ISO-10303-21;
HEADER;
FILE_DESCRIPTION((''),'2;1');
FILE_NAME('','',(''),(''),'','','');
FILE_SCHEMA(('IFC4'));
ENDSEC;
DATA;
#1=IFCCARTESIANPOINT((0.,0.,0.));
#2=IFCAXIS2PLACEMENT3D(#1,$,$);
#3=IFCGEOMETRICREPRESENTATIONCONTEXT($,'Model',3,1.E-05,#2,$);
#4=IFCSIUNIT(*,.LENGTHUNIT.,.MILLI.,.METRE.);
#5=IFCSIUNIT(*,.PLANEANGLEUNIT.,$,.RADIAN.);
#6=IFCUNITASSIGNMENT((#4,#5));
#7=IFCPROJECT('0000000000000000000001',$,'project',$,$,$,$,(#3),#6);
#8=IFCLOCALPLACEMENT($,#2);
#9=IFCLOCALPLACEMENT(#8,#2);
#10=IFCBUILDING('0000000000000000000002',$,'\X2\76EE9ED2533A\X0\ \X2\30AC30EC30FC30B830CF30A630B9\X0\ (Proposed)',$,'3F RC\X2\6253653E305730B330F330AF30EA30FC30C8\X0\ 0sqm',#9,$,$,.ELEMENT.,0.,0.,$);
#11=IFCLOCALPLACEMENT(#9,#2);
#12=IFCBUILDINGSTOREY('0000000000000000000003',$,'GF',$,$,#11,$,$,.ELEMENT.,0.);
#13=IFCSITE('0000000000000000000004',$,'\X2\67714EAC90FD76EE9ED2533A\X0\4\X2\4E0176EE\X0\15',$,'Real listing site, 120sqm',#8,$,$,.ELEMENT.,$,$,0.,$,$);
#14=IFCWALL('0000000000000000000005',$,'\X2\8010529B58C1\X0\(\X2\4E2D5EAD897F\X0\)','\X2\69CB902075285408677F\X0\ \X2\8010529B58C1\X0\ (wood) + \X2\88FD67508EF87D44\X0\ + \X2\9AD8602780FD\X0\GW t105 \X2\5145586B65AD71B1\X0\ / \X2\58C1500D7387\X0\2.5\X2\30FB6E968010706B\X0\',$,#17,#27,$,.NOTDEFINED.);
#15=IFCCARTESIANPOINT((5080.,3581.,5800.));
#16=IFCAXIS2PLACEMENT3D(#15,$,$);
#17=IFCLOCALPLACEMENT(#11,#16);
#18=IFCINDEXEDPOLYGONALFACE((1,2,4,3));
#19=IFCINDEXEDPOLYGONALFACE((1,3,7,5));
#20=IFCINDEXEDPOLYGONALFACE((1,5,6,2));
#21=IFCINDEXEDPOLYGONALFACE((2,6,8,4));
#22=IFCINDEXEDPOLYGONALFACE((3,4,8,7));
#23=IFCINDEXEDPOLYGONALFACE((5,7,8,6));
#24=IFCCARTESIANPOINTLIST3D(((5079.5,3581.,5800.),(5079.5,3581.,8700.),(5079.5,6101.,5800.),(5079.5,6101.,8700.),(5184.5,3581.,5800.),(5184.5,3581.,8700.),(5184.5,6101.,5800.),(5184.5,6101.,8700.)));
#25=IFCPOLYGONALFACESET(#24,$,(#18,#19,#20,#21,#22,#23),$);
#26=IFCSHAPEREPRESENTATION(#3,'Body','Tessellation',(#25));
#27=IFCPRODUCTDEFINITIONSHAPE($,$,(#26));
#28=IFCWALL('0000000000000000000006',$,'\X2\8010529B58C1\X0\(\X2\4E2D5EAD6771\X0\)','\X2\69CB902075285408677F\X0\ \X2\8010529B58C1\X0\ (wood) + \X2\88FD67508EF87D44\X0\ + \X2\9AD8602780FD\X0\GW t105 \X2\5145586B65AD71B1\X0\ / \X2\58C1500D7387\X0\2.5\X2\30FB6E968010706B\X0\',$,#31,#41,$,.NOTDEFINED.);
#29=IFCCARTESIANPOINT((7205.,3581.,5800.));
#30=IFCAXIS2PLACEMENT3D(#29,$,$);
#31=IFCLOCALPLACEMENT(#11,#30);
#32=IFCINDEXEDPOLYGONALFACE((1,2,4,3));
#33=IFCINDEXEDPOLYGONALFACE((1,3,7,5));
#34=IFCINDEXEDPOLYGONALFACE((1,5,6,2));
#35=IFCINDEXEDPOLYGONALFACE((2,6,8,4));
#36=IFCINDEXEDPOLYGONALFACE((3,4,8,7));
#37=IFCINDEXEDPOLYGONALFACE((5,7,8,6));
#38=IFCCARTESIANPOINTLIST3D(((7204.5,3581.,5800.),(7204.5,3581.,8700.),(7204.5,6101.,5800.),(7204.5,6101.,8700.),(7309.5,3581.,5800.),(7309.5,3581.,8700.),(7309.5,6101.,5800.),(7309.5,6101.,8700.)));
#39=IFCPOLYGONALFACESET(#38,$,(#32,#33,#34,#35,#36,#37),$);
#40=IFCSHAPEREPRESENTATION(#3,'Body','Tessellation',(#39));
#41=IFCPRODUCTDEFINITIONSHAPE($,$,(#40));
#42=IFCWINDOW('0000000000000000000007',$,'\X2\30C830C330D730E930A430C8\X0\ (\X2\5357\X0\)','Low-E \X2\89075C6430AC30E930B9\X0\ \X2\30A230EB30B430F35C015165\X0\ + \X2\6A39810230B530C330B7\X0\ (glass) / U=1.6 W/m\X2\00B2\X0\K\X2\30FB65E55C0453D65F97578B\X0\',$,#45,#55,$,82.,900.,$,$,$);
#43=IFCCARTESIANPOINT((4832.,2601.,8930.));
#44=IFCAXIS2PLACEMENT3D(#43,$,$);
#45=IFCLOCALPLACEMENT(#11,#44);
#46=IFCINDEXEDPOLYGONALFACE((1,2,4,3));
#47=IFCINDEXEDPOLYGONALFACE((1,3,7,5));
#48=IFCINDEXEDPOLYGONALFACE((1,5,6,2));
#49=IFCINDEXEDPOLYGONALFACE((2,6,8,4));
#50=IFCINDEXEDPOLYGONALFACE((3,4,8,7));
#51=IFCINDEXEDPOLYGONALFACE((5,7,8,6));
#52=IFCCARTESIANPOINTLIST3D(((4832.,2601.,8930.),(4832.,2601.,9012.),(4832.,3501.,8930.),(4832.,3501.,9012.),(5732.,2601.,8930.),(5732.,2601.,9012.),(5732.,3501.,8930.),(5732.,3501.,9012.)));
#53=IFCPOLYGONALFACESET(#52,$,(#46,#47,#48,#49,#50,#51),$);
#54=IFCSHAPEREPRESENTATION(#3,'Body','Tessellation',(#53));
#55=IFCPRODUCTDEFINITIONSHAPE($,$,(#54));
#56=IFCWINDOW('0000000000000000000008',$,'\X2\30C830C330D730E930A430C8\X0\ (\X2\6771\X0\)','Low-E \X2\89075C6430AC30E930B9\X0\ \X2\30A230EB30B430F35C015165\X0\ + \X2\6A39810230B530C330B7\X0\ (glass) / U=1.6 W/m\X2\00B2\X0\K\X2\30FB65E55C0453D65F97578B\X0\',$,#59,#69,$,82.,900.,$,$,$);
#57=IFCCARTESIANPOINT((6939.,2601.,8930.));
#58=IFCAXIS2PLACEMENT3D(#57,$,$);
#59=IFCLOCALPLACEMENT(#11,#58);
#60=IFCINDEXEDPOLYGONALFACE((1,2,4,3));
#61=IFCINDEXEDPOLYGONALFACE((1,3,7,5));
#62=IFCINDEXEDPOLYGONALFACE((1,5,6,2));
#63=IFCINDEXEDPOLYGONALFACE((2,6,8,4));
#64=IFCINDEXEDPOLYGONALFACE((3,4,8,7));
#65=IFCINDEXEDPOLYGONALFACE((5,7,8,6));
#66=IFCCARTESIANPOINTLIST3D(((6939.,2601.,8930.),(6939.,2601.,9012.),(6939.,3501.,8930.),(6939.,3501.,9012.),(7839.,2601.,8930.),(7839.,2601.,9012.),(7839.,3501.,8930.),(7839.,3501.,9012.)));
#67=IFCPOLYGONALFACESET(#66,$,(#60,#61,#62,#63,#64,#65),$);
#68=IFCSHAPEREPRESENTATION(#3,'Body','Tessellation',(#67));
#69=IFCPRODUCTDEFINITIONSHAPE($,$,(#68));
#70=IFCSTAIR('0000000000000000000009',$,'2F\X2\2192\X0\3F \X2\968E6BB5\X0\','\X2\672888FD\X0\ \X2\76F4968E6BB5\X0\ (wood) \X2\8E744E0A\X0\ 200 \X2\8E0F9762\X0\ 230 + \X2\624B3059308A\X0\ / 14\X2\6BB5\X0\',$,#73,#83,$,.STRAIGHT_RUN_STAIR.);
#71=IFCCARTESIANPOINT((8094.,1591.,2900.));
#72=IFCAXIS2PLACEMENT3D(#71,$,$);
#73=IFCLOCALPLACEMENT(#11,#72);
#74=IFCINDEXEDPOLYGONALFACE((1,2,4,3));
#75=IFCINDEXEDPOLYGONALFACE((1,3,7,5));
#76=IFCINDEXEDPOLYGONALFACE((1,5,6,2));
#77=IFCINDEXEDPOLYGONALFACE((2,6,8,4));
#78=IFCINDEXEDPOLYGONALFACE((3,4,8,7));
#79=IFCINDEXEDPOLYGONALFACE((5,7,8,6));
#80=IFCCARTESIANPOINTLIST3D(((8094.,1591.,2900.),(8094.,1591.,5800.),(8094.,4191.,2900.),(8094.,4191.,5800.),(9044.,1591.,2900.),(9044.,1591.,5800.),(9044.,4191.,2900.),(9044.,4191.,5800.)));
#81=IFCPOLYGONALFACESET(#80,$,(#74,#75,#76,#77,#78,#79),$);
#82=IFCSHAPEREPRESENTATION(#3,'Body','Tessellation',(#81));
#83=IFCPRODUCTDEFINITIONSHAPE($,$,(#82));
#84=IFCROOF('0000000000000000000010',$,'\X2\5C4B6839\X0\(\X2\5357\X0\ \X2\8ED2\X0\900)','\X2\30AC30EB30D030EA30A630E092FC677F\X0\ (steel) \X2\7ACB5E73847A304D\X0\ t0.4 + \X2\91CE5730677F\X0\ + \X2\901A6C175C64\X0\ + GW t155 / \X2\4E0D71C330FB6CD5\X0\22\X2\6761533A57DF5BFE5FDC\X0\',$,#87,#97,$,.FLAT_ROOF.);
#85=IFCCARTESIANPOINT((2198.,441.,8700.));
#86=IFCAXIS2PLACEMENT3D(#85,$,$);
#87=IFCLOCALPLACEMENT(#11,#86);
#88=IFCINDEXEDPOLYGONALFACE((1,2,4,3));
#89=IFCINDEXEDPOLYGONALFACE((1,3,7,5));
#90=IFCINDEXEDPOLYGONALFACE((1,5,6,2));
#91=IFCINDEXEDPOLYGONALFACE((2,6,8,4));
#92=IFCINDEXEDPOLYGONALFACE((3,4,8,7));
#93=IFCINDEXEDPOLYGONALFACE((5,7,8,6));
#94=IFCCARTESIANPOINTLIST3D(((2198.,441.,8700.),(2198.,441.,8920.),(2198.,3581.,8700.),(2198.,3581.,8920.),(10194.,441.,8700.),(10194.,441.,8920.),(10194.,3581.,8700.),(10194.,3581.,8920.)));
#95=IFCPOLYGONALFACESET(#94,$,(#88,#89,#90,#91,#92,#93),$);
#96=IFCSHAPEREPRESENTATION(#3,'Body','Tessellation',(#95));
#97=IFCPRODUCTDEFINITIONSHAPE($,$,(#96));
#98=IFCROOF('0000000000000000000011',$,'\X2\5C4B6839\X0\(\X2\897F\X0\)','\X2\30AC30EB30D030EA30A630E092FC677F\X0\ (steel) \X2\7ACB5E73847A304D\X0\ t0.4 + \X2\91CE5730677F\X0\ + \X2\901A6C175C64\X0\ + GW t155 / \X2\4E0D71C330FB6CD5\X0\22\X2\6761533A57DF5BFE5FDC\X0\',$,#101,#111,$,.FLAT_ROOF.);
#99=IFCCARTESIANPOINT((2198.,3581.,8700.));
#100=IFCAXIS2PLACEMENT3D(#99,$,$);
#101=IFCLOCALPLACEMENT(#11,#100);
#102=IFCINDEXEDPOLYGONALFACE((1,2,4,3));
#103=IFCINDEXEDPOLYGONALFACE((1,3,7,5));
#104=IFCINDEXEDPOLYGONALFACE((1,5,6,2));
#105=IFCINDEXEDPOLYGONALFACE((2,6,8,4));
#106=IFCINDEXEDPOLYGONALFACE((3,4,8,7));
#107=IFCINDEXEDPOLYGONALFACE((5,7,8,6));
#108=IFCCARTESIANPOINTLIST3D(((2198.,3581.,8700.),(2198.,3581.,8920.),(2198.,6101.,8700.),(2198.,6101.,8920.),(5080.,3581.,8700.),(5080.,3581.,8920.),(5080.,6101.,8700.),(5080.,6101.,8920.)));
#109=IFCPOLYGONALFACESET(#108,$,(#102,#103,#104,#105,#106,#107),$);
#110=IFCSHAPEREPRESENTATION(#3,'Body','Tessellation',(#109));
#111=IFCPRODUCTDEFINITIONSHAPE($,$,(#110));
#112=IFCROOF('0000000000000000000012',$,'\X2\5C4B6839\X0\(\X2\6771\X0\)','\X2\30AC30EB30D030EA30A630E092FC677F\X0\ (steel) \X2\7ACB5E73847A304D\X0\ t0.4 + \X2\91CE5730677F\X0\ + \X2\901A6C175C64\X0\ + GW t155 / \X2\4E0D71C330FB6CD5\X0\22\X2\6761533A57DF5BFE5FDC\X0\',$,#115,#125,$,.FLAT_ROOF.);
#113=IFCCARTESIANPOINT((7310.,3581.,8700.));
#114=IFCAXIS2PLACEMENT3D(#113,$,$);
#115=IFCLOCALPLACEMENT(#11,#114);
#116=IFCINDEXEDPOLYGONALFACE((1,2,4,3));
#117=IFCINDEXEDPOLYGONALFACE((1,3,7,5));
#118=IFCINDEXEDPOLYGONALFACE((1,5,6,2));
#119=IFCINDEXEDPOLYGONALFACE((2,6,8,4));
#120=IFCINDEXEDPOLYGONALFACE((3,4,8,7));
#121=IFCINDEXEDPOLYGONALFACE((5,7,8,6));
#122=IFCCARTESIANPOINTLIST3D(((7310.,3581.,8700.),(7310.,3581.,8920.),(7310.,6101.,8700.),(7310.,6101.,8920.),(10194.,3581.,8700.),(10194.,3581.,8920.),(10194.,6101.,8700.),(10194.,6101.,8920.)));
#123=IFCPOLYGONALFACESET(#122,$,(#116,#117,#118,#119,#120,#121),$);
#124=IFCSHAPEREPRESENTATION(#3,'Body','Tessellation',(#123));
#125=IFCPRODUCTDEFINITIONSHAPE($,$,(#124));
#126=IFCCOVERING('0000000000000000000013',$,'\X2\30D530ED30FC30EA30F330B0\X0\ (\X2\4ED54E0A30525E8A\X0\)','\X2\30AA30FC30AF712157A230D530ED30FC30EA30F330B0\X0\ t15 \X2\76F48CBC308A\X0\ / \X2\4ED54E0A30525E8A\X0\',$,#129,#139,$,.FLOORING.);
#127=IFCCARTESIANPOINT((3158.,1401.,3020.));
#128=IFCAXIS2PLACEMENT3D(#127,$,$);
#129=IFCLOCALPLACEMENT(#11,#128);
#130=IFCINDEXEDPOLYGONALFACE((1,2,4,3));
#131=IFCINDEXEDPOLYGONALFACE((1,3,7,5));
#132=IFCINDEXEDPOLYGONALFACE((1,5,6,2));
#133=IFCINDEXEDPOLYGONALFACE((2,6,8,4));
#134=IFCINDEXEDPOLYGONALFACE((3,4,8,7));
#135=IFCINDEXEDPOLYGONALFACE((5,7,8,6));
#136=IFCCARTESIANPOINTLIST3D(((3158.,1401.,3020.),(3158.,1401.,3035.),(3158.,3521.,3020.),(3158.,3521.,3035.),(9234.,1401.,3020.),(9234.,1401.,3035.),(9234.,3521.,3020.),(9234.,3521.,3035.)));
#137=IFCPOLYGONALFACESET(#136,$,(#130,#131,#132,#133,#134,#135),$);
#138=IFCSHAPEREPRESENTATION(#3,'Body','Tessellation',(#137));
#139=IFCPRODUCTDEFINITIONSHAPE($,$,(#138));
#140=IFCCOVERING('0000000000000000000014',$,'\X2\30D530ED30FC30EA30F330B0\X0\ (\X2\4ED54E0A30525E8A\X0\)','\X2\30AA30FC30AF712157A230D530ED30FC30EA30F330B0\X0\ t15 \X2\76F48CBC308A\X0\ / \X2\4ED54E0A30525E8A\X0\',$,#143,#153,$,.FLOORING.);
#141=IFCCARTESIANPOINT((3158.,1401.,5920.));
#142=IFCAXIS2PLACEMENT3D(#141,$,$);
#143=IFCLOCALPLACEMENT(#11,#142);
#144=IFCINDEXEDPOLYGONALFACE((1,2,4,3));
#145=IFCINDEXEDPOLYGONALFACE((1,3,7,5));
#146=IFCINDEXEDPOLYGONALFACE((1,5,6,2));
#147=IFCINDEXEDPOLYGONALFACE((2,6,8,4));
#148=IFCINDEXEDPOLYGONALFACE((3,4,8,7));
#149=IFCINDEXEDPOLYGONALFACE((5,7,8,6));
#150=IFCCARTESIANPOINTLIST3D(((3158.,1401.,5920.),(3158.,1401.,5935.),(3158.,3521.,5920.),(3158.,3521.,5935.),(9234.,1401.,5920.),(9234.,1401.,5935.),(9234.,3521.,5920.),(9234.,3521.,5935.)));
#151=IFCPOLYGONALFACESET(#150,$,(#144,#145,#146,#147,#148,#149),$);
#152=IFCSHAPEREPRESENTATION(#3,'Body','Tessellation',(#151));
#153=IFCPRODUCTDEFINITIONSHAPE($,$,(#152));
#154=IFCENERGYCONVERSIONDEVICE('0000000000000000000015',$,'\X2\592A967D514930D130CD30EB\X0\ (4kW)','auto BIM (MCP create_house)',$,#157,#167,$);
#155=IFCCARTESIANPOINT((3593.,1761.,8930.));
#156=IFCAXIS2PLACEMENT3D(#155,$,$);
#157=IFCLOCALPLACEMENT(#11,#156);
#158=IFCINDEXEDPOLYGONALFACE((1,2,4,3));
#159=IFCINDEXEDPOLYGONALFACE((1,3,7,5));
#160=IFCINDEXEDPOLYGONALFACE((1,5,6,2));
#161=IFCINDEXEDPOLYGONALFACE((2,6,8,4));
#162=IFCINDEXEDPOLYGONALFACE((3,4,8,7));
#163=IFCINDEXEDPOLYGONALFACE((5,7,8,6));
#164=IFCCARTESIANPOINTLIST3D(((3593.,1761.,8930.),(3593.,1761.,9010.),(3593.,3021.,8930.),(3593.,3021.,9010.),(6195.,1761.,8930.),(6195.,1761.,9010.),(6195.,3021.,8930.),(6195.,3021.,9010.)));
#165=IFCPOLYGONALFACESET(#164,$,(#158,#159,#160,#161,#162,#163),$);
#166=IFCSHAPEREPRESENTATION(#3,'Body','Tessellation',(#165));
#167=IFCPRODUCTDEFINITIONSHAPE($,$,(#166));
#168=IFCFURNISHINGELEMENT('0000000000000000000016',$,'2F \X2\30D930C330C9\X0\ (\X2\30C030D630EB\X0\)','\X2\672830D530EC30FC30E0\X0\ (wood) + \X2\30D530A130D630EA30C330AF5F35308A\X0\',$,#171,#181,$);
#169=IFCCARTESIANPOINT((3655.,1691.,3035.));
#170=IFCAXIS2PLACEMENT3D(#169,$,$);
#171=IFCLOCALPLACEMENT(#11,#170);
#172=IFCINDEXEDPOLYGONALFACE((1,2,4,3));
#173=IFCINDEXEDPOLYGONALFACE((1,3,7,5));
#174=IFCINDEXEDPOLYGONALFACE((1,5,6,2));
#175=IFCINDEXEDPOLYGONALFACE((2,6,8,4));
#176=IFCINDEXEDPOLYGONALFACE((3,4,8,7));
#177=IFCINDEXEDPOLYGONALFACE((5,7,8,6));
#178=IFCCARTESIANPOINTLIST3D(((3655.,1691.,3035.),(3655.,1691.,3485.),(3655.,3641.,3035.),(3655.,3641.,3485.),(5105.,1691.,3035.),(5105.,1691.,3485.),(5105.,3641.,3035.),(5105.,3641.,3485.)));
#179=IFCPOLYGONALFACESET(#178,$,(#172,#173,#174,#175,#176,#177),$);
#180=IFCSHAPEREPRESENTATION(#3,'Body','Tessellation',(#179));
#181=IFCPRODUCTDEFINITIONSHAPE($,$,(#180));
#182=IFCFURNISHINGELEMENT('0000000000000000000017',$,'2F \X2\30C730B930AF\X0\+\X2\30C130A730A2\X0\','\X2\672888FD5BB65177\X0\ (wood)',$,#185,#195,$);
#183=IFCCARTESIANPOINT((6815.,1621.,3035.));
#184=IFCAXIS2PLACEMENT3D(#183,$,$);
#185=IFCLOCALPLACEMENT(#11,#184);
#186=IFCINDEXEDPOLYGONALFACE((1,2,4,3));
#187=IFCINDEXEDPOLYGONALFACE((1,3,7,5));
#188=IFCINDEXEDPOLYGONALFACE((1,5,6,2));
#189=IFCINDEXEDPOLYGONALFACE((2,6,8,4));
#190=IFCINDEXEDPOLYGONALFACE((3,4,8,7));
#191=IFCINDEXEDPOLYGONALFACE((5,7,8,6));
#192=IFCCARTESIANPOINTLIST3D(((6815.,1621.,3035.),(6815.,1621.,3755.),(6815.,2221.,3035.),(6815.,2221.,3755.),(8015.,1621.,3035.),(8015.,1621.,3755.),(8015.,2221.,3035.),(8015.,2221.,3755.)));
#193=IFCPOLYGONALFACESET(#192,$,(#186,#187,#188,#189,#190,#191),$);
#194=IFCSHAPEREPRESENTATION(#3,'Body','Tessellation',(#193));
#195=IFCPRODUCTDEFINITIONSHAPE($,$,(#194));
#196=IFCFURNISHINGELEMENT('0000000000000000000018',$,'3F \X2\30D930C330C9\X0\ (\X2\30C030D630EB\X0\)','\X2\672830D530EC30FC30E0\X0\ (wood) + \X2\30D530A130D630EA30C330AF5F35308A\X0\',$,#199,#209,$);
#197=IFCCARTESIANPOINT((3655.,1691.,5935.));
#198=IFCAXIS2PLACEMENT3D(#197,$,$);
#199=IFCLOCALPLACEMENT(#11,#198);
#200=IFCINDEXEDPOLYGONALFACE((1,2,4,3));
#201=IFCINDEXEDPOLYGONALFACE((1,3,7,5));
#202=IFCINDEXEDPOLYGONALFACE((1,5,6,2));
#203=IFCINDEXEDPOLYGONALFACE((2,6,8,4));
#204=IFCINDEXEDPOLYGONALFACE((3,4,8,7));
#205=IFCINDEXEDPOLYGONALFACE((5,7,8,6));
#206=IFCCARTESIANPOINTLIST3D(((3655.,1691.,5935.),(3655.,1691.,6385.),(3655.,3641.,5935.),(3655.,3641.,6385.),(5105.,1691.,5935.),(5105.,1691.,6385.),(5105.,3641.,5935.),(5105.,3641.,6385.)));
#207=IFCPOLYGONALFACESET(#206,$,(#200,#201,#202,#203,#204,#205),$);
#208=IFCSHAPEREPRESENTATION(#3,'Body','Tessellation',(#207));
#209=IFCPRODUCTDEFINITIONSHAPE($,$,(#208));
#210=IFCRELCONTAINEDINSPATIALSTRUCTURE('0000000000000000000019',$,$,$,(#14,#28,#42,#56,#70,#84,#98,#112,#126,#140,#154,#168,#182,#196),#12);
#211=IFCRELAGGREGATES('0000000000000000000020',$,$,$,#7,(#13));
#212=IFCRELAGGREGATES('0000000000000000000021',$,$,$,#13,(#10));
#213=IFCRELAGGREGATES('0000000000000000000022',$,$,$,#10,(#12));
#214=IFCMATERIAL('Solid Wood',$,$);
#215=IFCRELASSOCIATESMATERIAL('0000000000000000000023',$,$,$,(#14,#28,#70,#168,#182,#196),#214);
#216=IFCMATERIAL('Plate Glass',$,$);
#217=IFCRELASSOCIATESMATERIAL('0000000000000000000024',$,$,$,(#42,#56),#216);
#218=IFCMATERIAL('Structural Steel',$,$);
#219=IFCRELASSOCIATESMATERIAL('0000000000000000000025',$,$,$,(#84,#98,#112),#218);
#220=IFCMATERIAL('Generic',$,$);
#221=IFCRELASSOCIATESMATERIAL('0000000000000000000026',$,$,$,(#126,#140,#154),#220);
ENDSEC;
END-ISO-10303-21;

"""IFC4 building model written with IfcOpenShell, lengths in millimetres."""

from ifc_helpers import new_model, si_unit, frame, frame_2d, origin, place, context, project, spatial, rectangle, extrude, material, element, save


model = new_model("IFC4")

# Units and contexts
model_context = context("Model", 3, precision=1e-05, world=origin())
ifc_project = project(units=[si_unit("LENGTHUNIT", "METRE", prefix="MILLI"), si_unit("PLANEANGLEUNIT", "RADIAN")], contexts=[model_context])

# Site, building, storey
site_placement = place(None, origin())
site = spatial("IfcSite", under=ifc_project, at=site_placement, Name="東京都目黒区4丁目15", ObjectType="Real listing site, 120sqm", CompositionType="ELEMENT", RefElevation=0.0)
building_placement = place(site_placement, origin())
building = spatial("IfcBuilding", under=site, at=building_placement, Name="目黒区 ガレージハウス (Proposed)", ObjectType="3F RC打放しコンクリート 0sqm", CompositionType="ELEMENT", ElevationOfRefHeight=0.0, ElevationOfTerrain=0.0)
storey_placement = place(building_placement, origin())
storey = spatial("IfcBuildingStorey", under=building, at=storey_placement, Name="GF", CompositionType="ELEMENT", Elevation=0.0)

# Shared definitions
ifc_material_1 = material(Name="Solid Wood")

# Shared definitions
ifc_material_2 = material(Name="Plate Glass")

# Walls
wall_1_placement = place(storey_placement, frame((5080.0, 3581.0, 5800.0)))
element("IfcWall", 1, at=wall_1_placement, inside=storey, material=ifc_material_1, Name="耐力壁(中庭西)", Description="構造用合板 耐力壁 (wood) + 製材軸組 + 高性能GW t105 充填断熱 / 壁倍率2.5・準耐火", PredefinedType="NOTDEFINED", context=model_context, shape_type="SweptSolid", body=[
    extrude(rectangle(XDim=105.0, YDim=2520.0, at=frame_2d((52.0, 1260.0))), frame((5080.0, 3581.0, 5800.0)), (0.0, 0.0, 1.0), 2900.0),
])
wall_2_placement = place(storey_placement, frame((7205.0, 3581.0, 5800.0)))
element("IfcWall", 2, at=wall_2_placement, inside=storey, material=ifc_material_1, Name="耐力壁(中庭東)", Description="構造用合板 耐力壁 (wood) + 製材軸組 + 高性能GW t105 充填断熱 / 壁倍率2.5・準耐火", PredefinedType="NOTDEFINED", context=model_context, shape_type="SweptSolid", body=[
    extrude(rectangle(XDim=105.0, YDim=2520.0, at=frame_2d((52.0, 1260.0))), frame((7205.0, 3581.0, 5800.0)), (0.0, 0.0, 1.0), 2900.0),
])

# Windows
window_1_placement = place(storey_placement, frame((4832.0, 2601.0, 8930.0)))
element("IfcWindow", 3, at=window_1_placement, inside=storey, material=ifc_material_2, Name="トップライト (南)", Description="Low-E 複層ガラス アルゴン封入 + 樹脂サッシ (glass) / U=1.6 W/m²K・日射取得型", OverallHeight=82.0, OverallWidth=900.0, context=model_context, shape_type="SweptSolid", body=[
    extrude(rectangle(XDim=900.0, YDim=900.0, at=frame_2d((450.0, 450.0))), frame((4832.0, 2601.0, 8930.0)), (0.0, 0.0, 1.0), 82.0),
])
window_2_placement = place(storey_placement, frame((6939.0, 2601.0, 8930.0)))
element("IfcWindow", 4, at=window_2_placement, inside=storey, material=ifc_material_2, Name="トップライト (東)", Description="Low-E 複層ガラス アルゴン封入 + 樹脂サッシ (glass) / U=1.6 W/m²K・日射取得型", OverallHeight=82.0, OverallWidth=900.0, context=model_context, shape_type="SweptSolid", body=[
    extrude(rectangle(XDim=900.0, YDim=900.0, at=frame_2d((450.0, 450.0))), frame((6939.0, 2601.0, 8930.0)), (0.0, 0.0, 1.0), 82.0),
])

# Stair
stair_placement = place(storey_placement, frame((8094.0, 1591.0, 2900.0)))
element("IfcStair", 5, at=stair_placement, inside=storey, material=ifc_material_1, Name="2F→3F 階段", Description="木製 直階段 (wood) 蹴上 200 踏面 230 + 手すり / 14段", PredefinedType="STRAIGHT_RUN_STAIR", context=model_context, shape_type="SweptSolid", body=[
    extrude(rectangle(XDim=950.0, YDim=2600.0, at=frame_2d((475.0, 1300.0))), frame((8094.0, 1591.0, 2900.0)), (0.0, 0.0, 1.0), 2900.0),
])

# Roofs
ifc_material_3 = material(Name="Structural Steel")
roof_1_placement = place(storey_placement, frame((2198.0, 441.0, 8700.0)))
element("IfcRoof", 6, at=roof_1_placement, inside=storey, material=ifc_material_3, Name="屋根(南 軒900)", Description="ガルバリウム鋼板 (steel) 立平葺き t0.4 + 野地板 + 通気層 + GW t155 / 不燃・法22条区域対応", PredefinedType="FLAT_ROOF", context=model_context, shape_type="SweptSolid", body=[
    extrude(rectangle(XDim=7996.0, YDim=3140.0, at=frame_2d((3998.0, 1570.0))), frame((2198.0, 441.0, 8700.0)), (0.0, 0.0, 1.0), 220.0),
])
roof_2_placement = place(storey_placement, frame((2198.0, 3581.0, 8700.0)))
element("IfcRoof", 7, at=roof_2_placement, inside=storey, material=ifc_material_3, Name="屋根(西)", Description="ガルバリウム鋼板 (steel) 立平葺き t0.4 + 野地板 + 通気層 + GW t155 / 不燃・法22条区域対応", PredefinedType="FLAT_ROOF", context=model_context, shape_type="SweptSolid", body=[
    extrude(rectangle(XDim=2882.0, YDim=2520.0, at=frame_2d((1441.0, 1260.0))), frame((2198.0, 3581.0, 8700.0)), (0.0, 0.0, 1.0), 220.0),
])
roof_3_placement = place(storey_placement, frame((7310.0, 3581.0, 8700.0)))
element("IfcRoof", 8, at=roof_3_placement, inside=storey, material=ifc_material_3, Name="屋根(東)", Description="ガルバリウム鋼板 (steel) 立平葺き t0.4 + 野地板 + 通気層 + GW t155 / 不燃・法22条区域対応", PredefinedType="FLAT_ROOF", context=model_context, shape_type="SweptSolid", body=[
    extrude(rectangle(XDim=2884.0, YDim=2520.0, at=frame_2d((1442.0, 1260.0))), frame((7310.0, 3581.0, 8700.0)), (0.0, 0.0, 1.0), 220.0),
])

# Coverings
ifc_material_4 = material(Name="Generic")
covering_1_placement = place(storey_placement, frame((3158.0, 1401.0, 3020.0)))
element("IfcCovering", 9, at=covering_1_placement, inside=storey, material=ifc_material_4, Name="フローリング (仕上げ床)", Description="オーク無垢フローリング t15 直貼り / 仕上げ床", PredefinedType="FLOORING", context=model_context, shape_type="SweptSolid", body=[
    extrude(rectangle(XDim=6076.0, YDim=2120.0, at=frame_2d((3038.0, 1060.0))), frame((3158.0, 1401.0, 3020.0)), (0.0, 0.0, 1.0), 15.0),
])
covering_2_placement = place(storey_placement, frame((3158.0, 1401.0, 5920.0)))
element("IfcCovering", 10, at=covering_2_placement, inside=storey, material=ifc_material_4, Name="フローリング (仕上げ床)", Description="オーク無垢フローリング t15 直貼り / 仕上げ床", PredefinedType="FLOORING", context=model_context, shape_type="SweptSolid", body=[
    extrude(rectangle(XDim=6076.0, YDim=2120.0, at=frame_2d((3038.0, 1060.0))), frame((3158.0, 1401.0, 5920.0)), (0.0, 0.0, 1.0), 15.0),
])

# Energy conversion device
energy_conversion_device_placement = place(storey_placement, frame((3593.0, 1761.0, 8930.0)))
element("IfcEnergyConversionDevice", 11, at=energy_conversion_device_placement, inside=storey, material=ifc_material_4, Name="太陽光パネル (4kW)", Description="auto BIM (MCP create_house)", context=model_context, shape_type="SweptSolid", body=[
    extrude(rectangle(XDim=2602.0, YDim=1260.0, at=frame_2d((1301.0, 630.0))), frame((3593.0, 1761.0, 8930.0)), (0.0, 0.0, 1.0), 80.0),
])

# Furnishing elements
furnishing_1_placement = place(storey_placement, frame((3655.0, 1691.0, 3035.0)))
element("IfcFurnishingElement", 12, at=furnishing_1_placement, inside=storey, material=ifc_material_1, Name="2F ベッド (ダブル)", Description="木フレーム (wood) + ファブリック張り", context=model_context, shape_type="SweptSolid", body=[
    extrude(rectangle(XDim=1450.0, YDim=1950.0, at=frame_2d((725.0, 975.0))), frame((3655.0, 1691.0, 3035.0)), (0.0, 0.0, 1.0), 450.0),
])
furnishing_2_placement = place(storey_placement, frame((6815.0, 1621.0, 3035.0)))
element("IfcFurnishingElement", 13, at=furnishing_2_placement, inside=storey, material=ifc_material_1, Name="2F デスク+チェア", Description="木製家具 (wood)", context=model_context, shape_type="SweptSolid", body=[
    extrude(rectangle(XDim=1200.0, YDim=600.0, at=frame_2d((600.0, 300.0))), frame((6815.0, 1621.0, 3035.0)), (0.0, 0.0, 1.0), 720.0),
])
furnishing_3_placement = place(storey_placement, frame((3655.0, 1691.0, 5935.0)))
element("IfcFurnishingElement", 14, at=furnishing_3_placement, inside=storey, material=ifc_material_1, Name="3F ベッド (ダブル)", Description="木フレーム (wood) + ファブリック張り", context=model_context, shape_type="SweptSolid", body=[
    extrude(rectangle(XDim=1450.0, YDim=1950.0, at=frame_2d((725.0, 975.0))), frame((3655.0, 1691.0, 5935.0)), (0.0, 0.0, 1.0), 450.0),
])

save(model, "model.ifc")
